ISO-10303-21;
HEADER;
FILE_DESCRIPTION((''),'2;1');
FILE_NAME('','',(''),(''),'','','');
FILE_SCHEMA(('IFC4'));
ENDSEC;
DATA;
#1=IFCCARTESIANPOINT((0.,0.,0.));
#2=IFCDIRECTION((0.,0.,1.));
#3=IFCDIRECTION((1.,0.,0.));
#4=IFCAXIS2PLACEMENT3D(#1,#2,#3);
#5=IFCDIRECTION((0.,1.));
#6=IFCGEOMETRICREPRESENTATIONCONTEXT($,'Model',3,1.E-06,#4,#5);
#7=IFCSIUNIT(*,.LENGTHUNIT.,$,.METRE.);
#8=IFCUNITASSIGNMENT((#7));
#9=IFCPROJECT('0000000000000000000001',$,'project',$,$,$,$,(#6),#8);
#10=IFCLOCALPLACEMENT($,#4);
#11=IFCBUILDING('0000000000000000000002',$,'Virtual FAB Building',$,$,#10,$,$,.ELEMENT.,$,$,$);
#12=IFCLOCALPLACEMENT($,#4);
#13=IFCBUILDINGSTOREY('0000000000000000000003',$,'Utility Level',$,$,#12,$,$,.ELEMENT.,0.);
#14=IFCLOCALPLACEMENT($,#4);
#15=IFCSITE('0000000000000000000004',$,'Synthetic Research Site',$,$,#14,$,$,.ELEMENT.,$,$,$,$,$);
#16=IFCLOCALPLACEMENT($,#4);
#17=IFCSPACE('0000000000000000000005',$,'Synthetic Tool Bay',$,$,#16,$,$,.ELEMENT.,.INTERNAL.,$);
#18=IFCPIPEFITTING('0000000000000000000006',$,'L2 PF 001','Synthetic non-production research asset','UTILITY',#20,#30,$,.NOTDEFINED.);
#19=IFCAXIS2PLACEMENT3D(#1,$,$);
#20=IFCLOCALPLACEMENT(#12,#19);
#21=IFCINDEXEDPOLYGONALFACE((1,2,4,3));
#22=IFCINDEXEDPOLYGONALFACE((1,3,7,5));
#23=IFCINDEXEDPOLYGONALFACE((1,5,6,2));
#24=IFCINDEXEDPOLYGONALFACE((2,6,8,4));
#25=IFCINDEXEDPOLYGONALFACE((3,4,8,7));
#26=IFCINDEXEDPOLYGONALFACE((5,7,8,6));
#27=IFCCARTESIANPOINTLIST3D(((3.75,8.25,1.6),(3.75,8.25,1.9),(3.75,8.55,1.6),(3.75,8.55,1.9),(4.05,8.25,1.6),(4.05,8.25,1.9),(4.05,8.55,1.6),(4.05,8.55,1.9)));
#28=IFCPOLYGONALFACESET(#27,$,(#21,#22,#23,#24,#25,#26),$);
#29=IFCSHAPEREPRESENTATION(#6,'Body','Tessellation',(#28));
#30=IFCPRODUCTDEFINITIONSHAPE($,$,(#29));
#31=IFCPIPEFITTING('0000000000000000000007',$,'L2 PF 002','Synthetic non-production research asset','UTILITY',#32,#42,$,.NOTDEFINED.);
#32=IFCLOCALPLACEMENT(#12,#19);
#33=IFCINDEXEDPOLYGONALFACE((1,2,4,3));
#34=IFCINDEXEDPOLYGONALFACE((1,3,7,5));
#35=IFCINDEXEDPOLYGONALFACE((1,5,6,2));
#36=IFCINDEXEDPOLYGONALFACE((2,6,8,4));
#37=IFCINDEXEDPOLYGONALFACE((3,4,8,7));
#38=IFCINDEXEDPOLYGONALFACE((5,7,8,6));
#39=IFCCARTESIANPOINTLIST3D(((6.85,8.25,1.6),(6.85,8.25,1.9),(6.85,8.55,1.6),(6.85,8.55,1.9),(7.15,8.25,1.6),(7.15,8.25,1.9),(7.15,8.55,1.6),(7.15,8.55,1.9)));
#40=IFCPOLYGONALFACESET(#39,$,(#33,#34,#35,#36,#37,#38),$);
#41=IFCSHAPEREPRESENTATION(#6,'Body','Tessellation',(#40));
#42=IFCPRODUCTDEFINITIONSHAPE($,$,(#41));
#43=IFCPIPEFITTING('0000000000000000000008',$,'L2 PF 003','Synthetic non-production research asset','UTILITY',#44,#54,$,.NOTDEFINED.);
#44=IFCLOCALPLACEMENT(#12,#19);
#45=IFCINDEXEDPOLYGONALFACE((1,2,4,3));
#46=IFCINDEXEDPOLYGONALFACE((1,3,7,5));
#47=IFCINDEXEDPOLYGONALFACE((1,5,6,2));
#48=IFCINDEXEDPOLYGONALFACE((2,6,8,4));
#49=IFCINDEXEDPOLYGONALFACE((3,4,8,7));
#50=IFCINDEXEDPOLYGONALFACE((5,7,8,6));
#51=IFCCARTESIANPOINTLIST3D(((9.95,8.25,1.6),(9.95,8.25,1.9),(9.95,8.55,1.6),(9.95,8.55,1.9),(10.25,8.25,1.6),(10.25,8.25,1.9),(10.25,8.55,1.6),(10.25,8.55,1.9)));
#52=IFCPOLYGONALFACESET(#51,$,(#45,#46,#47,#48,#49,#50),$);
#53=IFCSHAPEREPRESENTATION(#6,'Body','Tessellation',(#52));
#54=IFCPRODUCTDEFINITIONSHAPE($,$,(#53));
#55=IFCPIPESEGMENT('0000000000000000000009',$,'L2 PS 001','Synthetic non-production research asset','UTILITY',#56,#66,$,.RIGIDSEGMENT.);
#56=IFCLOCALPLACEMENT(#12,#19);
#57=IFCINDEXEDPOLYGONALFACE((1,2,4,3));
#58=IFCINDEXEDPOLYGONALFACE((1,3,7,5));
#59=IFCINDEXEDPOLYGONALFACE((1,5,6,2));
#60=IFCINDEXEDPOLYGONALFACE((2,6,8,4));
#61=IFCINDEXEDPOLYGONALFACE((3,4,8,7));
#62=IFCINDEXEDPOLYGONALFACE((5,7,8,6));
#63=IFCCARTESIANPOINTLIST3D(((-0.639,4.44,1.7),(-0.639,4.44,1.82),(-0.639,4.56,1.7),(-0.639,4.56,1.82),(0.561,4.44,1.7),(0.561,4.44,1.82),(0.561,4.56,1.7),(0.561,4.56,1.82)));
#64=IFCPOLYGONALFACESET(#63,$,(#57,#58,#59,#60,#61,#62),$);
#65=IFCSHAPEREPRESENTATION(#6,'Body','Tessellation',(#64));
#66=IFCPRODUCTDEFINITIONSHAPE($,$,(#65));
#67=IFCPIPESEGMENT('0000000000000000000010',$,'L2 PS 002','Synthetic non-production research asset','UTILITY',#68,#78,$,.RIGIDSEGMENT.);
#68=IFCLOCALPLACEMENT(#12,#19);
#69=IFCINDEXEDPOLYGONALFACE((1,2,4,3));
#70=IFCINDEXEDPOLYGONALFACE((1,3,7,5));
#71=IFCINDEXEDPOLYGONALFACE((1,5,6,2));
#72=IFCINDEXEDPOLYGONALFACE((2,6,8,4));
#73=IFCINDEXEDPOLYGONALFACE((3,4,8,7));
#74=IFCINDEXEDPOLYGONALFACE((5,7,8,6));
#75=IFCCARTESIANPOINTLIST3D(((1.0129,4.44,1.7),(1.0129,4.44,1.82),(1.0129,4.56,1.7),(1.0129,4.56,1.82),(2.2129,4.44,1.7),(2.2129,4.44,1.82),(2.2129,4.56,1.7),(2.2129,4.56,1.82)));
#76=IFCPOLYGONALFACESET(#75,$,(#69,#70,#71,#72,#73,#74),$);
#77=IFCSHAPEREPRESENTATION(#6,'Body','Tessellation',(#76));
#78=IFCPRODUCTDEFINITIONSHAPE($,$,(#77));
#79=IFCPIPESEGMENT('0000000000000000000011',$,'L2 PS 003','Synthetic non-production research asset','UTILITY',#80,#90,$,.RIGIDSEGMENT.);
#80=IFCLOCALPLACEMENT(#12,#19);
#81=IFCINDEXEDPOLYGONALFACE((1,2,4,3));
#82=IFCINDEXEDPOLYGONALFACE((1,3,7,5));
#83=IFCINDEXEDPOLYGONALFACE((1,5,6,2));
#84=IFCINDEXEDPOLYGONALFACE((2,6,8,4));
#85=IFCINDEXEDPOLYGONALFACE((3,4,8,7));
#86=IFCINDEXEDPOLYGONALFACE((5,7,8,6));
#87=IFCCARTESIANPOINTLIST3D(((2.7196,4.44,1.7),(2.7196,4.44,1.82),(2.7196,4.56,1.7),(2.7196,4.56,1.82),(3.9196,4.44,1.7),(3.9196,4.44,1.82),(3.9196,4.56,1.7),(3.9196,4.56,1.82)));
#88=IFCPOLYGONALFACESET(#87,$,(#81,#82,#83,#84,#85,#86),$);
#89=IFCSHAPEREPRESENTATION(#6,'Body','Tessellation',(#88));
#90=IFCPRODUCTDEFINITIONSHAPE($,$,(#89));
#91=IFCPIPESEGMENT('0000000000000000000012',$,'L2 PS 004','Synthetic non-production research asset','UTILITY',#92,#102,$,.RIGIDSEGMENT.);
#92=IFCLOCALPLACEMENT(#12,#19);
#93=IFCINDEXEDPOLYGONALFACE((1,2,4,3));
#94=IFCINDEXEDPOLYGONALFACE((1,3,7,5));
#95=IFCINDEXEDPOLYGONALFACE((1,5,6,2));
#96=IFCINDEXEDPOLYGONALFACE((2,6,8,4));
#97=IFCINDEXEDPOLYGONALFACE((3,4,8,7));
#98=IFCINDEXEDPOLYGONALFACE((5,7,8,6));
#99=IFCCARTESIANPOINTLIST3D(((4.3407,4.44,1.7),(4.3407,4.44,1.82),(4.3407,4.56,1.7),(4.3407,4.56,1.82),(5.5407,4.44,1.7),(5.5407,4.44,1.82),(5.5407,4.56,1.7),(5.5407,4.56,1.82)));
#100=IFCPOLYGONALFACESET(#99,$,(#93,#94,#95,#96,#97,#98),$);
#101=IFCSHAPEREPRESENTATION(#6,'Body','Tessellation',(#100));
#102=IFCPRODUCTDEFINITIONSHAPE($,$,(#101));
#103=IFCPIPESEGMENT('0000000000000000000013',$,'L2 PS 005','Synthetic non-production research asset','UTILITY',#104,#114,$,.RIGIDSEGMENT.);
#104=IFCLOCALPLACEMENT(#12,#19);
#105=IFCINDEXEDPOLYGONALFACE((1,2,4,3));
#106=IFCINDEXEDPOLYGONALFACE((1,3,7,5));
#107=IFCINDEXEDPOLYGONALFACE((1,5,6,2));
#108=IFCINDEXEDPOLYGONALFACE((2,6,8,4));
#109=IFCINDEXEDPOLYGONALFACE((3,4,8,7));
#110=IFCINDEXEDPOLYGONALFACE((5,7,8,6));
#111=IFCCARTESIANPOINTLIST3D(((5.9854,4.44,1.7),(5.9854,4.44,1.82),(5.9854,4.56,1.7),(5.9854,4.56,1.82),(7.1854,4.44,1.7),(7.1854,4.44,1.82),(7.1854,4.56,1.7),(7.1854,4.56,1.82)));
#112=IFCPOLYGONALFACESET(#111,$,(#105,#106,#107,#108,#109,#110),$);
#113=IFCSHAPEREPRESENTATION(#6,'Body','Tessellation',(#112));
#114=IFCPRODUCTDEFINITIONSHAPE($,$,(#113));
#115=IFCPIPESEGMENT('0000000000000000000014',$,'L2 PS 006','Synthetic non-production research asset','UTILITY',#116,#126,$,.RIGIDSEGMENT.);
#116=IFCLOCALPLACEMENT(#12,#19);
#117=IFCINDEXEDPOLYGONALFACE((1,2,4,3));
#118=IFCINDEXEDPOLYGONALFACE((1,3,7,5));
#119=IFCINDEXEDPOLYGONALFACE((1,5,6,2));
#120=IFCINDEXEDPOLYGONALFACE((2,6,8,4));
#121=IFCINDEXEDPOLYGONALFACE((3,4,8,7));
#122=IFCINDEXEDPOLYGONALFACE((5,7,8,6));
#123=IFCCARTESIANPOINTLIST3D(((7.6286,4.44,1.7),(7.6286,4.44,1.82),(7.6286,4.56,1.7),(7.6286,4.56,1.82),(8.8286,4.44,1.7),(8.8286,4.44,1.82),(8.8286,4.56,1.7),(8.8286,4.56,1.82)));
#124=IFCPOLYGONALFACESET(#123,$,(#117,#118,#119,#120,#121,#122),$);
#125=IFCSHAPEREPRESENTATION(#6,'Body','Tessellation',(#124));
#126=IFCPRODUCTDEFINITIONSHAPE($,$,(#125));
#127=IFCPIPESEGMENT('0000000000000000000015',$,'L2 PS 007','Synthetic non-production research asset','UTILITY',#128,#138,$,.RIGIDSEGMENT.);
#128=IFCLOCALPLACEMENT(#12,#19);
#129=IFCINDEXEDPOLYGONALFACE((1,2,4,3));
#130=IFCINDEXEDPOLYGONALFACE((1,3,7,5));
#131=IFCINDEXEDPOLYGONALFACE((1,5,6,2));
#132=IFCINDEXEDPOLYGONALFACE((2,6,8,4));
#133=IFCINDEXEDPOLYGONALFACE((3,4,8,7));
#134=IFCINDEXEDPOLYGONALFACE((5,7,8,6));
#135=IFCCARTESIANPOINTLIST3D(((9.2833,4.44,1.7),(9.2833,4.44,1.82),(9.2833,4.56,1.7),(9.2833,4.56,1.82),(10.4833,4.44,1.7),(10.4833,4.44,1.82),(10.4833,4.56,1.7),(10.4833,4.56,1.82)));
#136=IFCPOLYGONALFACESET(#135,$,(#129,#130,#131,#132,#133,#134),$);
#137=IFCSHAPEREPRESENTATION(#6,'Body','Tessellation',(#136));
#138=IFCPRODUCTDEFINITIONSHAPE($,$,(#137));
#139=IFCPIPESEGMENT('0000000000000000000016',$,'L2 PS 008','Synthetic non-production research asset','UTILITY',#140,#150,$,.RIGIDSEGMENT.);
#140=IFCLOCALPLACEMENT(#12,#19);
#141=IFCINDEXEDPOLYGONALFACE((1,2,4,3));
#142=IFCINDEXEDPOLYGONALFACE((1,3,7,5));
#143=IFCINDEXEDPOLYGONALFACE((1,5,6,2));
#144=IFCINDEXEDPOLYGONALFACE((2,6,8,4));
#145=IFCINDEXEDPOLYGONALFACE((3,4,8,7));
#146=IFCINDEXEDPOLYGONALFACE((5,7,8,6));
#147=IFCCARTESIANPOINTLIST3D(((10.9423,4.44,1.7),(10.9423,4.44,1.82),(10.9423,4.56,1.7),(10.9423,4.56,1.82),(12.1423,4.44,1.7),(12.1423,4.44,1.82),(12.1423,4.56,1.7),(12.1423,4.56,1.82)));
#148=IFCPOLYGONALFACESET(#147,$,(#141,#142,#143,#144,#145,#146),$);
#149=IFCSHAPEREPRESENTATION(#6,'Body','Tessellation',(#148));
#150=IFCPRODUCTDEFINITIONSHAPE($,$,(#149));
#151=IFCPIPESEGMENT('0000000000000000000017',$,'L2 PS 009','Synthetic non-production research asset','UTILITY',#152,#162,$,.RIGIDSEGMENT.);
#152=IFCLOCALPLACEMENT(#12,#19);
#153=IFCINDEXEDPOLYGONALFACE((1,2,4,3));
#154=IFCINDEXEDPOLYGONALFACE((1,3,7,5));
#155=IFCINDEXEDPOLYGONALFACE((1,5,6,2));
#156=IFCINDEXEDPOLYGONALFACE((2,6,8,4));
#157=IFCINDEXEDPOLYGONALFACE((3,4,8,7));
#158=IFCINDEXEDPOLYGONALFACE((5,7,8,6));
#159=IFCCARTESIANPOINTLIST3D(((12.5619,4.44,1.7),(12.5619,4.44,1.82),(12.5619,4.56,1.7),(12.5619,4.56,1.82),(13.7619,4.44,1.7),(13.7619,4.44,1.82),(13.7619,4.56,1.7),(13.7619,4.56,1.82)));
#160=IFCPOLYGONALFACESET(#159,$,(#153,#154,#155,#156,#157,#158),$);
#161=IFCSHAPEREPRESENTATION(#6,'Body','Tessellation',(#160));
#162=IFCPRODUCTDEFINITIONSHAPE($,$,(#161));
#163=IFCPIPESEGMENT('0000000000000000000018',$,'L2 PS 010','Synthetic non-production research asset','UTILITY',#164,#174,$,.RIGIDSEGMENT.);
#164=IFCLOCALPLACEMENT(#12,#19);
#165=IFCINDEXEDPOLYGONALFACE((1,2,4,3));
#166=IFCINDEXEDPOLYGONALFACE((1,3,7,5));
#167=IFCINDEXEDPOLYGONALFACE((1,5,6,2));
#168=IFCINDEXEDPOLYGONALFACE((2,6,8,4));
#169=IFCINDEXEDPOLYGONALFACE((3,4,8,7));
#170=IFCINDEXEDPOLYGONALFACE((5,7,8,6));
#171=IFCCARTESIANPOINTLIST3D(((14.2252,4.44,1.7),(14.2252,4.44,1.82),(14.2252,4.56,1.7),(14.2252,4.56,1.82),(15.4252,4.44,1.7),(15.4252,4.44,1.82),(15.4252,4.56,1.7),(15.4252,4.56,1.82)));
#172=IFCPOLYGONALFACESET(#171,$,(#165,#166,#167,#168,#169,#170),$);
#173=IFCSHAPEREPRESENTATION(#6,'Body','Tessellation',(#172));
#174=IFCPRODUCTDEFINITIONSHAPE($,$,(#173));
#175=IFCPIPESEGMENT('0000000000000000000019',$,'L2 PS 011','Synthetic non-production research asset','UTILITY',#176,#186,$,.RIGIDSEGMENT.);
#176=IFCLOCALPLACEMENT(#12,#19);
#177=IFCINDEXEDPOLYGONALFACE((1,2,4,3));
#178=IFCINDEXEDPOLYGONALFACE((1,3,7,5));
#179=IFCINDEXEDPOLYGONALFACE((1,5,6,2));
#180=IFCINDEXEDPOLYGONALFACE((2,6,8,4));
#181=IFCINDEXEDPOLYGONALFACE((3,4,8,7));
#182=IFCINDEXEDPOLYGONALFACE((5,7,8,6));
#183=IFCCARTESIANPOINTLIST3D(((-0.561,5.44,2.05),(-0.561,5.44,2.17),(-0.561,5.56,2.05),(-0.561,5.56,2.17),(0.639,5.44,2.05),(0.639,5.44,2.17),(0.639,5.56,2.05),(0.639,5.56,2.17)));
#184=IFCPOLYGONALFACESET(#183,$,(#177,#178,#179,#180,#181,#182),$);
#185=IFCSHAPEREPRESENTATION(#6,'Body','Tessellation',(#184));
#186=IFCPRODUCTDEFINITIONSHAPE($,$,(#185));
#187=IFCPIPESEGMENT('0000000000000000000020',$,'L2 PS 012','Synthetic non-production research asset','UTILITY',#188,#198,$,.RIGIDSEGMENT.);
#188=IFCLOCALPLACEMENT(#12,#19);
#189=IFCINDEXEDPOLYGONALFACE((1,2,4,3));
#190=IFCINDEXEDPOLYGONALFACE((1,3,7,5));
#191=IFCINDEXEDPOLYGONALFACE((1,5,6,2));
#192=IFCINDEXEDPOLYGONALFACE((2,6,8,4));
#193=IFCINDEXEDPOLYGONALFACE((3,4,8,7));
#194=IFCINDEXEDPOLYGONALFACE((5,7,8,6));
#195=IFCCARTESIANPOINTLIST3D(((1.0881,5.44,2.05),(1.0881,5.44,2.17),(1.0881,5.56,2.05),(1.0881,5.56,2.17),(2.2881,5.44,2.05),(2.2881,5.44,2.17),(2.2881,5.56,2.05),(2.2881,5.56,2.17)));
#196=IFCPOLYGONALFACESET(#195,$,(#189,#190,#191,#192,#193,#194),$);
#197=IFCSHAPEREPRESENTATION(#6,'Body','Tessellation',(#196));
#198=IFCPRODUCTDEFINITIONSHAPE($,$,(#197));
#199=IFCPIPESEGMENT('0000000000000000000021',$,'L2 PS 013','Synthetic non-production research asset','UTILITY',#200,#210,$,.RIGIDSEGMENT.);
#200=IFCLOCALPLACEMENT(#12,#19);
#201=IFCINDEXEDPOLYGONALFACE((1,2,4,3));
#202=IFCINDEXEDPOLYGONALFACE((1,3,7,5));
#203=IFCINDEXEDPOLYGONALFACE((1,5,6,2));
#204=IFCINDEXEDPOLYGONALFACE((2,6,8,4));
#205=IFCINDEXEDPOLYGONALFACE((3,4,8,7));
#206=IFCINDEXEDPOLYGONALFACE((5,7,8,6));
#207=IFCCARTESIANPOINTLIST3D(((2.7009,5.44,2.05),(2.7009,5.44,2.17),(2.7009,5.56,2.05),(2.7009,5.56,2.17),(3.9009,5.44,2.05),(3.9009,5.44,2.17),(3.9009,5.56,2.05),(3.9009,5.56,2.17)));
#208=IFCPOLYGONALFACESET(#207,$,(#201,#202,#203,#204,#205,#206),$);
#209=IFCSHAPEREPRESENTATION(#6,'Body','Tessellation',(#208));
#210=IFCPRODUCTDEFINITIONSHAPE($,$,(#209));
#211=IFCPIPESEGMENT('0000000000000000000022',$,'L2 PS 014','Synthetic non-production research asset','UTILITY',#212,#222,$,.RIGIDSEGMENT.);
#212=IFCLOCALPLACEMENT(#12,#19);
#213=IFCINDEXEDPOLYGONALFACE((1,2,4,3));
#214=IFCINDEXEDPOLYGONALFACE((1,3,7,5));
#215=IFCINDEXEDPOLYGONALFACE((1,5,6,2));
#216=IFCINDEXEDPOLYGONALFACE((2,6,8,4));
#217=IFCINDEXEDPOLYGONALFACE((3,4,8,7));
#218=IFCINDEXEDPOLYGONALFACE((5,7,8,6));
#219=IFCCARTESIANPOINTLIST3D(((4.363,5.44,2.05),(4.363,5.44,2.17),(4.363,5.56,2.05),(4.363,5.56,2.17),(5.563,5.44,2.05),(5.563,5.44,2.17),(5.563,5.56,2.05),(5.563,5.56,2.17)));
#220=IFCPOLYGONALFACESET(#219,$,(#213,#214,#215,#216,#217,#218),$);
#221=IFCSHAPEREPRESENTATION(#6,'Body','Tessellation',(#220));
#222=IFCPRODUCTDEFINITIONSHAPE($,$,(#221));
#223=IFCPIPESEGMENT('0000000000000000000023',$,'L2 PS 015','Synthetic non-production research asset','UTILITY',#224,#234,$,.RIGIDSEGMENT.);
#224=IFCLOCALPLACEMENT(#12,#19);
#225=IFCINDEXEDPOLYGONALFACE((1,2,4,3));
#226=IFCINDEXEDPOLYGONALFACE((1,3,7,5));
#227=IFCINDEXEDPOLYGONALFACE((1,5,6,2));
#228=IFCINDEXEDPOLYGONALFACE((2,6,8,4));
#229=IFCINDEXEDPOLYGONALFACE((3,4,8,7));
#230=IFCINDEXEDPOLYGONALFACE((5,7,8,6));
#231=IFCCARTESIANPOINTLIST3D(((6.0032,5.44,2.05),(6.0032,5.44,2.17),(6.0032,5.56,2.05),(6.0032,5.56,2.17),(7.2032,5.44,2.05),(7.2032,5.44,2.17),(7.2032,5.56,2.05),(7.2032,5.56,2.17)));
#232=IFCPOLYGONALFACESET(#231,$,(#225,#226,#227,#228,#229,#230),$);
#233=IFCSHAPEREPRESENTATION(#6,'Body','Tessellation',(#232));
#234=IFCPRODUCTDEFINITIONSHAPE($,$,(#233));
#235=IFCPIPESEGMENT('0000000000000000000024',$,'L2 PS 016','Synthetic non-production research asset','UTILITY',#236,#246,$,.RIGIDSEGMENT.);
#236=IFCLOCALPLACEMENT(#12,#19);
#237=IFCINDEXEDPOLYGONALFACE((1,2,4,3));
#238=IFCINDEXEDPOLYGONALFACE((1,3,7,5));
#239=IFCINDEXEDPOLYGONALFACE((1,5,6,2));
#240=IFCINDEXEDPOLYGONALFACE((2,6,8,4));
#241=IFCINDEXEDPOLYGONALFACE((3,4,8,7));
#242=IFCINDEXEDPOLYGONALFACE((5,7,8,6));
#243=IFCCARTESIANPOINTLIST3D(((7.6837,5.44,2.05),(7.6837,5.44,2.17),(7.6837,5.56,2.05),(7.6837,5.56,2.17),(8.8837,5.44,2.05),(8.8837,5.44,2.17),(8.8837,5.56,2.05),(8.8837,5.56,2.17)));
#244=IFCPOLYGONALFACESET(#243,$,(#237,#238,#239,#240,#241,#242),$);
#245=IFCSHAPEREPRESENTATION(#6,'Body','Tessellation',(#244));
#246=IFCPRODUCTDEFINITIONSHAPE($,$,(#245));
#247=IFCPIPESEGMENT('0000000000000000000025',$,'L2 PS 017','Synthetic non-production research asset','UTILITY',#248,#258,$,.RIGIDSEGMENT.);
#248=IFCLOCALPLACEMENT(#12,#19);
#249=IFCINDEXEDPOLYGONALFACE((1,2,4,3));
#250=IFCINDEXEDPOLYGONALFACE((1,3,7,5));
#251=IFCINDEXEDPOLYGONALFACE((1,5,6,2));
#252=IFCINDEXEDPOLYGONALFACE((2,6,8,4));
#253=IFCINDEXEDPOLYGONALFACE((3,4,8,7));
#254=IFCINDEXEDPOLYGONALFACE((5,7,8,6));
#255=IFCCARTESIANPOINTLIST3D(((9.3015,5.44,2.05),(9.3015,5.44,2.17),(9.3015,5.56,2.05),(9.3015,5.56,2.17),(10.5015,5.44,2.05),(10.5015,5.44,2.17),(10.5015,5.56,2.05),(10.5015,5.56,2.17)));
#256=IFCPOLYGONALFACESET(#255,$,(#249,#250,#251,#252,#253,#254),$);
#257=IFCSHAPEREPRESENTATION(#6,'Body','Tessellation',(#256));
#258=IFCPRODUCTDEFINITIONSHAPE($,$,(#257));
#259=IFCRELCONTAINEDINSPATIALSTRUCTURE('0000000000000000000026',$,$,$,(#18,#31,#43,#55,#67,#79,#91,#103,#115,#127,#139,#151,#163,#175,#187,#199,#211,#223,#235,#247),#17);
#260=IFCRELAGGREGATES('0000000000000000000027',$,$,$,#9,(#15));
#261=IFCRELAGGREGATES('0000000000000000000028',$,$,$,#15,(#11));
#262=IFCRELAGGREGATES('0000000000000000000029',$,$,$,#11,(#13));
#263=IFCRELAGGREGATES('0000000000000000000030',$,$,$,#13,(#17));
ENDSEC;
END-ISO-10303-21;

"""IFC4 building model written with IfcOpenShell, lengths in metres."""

from ifc_helpers import new_model, si_unit, direction, frame, origin_with_axes, origin_2d_with_axis, place, context, project, spatial, rectangle, extrude, element, save


model = new_model("IFC4")

# Units and contexts
model_context = context("Model", 3, precision=1e-06, world=origin_with_axes(), true_north=direction((0.0, 1.0)))
ifc_project = project(units=[si_unit("LENGTHUNIT", "METRE")], contexts=[model_context])

# Site, building, storey, space
site_placement = place(None, origin_with_axes())
site = spatial("IfcSite", under=ifc_project, at=site_placement, Name="Synthetic Research Site", CompositionType="ELEMENT")
building_placement = place(None, origin_with_axes())
building = spatial("IfcBuilding", under=site, at=building_placement, Name="Virtual FAB Building", CompositionType="ELEMENT")
storey_placement = place(None, origin_with_axes())
storey = spatial("IfcBuildingStorey", under=building, at=storey_placement, Name="Utility Level", CompositionType="ELEMENT", Elevation=0.0)
space_placement = place(None, origin_with_axes())
space = spatial("IfcSpace", under=storey, at=space_placement, Name="Synthetic Tool Bay", CompositionType="ELEMENT", PredefinedType="INTERNAL")

# Pipe fittings
for number, where, z_axis, x_axis, name in (
    (1, (3.9, 8.4, 1.6), (0.0, 0.0, 1.0), (1.0, 0.0, 0.0), "L2 PF 001"),
    (2, (7.0, 8.4, 1.6), (0.0, 0.0, 1.0), (1.0, 0.0, 0.0), "L2 PF 002"),
    (3, (10.1, 8.4, 1.6), (0.0, 0.0, 1.0), (1.0, 0.0, 0.0), "L2 PF 003"),
):
    element("IfcPipeFitting", number, at=place(None, frame(where, z_axis=z_axis, x_axis=x_axis)), inside=space, Name=name, Description="Synthetic non-production research asset", ObjectType="UTILITY", PredefinedType="NOTDEFINED", context=model_context, shape_type="SweptSolid", body=[
        extrude(rectangle(XDim=0.3, YDim=0.3, at=origin_2d_with_axis()), origin_with_axes(), (0.0, 0.0, 1.0), 0.3),
    ])

# Pipe segments
for number, where, z_axis, x_axis, name in (
    (4, (-0.039, 4.5, 1.7), (0.0, 0.0, 1.0), (1.0, 0.0, 0.0), "L2 PS 001"),
    (5, (1.6129, 4.5, 1.7), (0.0, 0.0, 1.0), (1.0, 0.0, 0.0), "L2 PS 002"),
    (6, (3.3196, 4.5, 1.7), (0.0, 0.0, 1.0), (1.0, 0.0, 0.0), "L2 PS 003"),
    (7, (4.9407, 4.5, 1.7), (0.0, 0.0, 1.0), (1.0, 0.0, 0.0), "L2 PS 004"),
    (8, (6.5854, 4.5, 1.7), (0.0, 0.0, 1.0), (1.0, 0.0, 0.0), "L2 PS 005"),
    (9, (8.2286, 4.5, 1.7), (0.0, 0.0, 1.0), (1.0, 0.0, 0.0), "L2 PS 006"),
    (10, (9.8833, 4.5, 1.7), (0.0, 0.0, 1.0), (1.0, 0.0, 0.0), "L2 PS 007"),
    (11, (11.5423, 4.5, 1.7), (0.0, 0.0, 1.0), (1.0, 0.0, 0.0), "L2 PS 008"),
    (12, (13.1619, 4.5, 1.7), (0.0, 0.0, 1.0), (1.0, 0.0, 0.0), "L2 PS 009"),
    (13, (14.8252, 4.5, 1.7), (0.0, 0.0, 1.0), (1.0, 0.0, 0.0), "L2 PS 010"),
    (14, (0.039, 5.5, 2.05), (0.0, 0.0, 1.0), (1.0, 0.0, 0.0), "L2 PS 011"),
    (15, (1.6881, 5.5, 2.05), (0.0, 0.0, 1.0), (1.0, 0.0, 0.0), "L2 PS 012"),
    (16, (3.3009, 5.5, 2.05), (0.0, 0.0, 1.0), (1.0, 0.0, 0.0), "L2 PS 013"),
    (17, (4.963, 5.5, 2.05), (0.0, 0.0, 1.0), (1.0, 0.0, 0.0), "L2 PS 014"),
    (18, (6.6032, 5.5, 2.05), (0.0, 0.0, 1.0), (1.0, 0.0, 0.0), "L2 PS 015"),
    (19, (8.2837, 5.5, 2.05), (0.0, 0.0, 1.0), (1.0, 0.0, 0.0), "L2 PS 016"),
    (20, (9.9015, 5.5, 2.05), (0.0, 0.0, 1.0), (1.0, 0.0, 0.0), "L2 PS 017"),
):
    element("IfcPipeSegment", number, at=place(None, frame(where, z_axis=z_axis, x_axis=x_axis)), inside=space, Name=name, Description="Synthetic non-production research asset", ObjectType="UTILITY", PredefinedType="RIGIDSEGMENT", context=model_context, shape_type="SweptSolid", body=[
        extrude(rectangle(XDim=1.2, YDim=0.12, at=origin_2d_with_axis()), origin_with_axes(), (0.0, 0.0, 1.0), 0.12),
    ])

save(model, "model.ifc")
